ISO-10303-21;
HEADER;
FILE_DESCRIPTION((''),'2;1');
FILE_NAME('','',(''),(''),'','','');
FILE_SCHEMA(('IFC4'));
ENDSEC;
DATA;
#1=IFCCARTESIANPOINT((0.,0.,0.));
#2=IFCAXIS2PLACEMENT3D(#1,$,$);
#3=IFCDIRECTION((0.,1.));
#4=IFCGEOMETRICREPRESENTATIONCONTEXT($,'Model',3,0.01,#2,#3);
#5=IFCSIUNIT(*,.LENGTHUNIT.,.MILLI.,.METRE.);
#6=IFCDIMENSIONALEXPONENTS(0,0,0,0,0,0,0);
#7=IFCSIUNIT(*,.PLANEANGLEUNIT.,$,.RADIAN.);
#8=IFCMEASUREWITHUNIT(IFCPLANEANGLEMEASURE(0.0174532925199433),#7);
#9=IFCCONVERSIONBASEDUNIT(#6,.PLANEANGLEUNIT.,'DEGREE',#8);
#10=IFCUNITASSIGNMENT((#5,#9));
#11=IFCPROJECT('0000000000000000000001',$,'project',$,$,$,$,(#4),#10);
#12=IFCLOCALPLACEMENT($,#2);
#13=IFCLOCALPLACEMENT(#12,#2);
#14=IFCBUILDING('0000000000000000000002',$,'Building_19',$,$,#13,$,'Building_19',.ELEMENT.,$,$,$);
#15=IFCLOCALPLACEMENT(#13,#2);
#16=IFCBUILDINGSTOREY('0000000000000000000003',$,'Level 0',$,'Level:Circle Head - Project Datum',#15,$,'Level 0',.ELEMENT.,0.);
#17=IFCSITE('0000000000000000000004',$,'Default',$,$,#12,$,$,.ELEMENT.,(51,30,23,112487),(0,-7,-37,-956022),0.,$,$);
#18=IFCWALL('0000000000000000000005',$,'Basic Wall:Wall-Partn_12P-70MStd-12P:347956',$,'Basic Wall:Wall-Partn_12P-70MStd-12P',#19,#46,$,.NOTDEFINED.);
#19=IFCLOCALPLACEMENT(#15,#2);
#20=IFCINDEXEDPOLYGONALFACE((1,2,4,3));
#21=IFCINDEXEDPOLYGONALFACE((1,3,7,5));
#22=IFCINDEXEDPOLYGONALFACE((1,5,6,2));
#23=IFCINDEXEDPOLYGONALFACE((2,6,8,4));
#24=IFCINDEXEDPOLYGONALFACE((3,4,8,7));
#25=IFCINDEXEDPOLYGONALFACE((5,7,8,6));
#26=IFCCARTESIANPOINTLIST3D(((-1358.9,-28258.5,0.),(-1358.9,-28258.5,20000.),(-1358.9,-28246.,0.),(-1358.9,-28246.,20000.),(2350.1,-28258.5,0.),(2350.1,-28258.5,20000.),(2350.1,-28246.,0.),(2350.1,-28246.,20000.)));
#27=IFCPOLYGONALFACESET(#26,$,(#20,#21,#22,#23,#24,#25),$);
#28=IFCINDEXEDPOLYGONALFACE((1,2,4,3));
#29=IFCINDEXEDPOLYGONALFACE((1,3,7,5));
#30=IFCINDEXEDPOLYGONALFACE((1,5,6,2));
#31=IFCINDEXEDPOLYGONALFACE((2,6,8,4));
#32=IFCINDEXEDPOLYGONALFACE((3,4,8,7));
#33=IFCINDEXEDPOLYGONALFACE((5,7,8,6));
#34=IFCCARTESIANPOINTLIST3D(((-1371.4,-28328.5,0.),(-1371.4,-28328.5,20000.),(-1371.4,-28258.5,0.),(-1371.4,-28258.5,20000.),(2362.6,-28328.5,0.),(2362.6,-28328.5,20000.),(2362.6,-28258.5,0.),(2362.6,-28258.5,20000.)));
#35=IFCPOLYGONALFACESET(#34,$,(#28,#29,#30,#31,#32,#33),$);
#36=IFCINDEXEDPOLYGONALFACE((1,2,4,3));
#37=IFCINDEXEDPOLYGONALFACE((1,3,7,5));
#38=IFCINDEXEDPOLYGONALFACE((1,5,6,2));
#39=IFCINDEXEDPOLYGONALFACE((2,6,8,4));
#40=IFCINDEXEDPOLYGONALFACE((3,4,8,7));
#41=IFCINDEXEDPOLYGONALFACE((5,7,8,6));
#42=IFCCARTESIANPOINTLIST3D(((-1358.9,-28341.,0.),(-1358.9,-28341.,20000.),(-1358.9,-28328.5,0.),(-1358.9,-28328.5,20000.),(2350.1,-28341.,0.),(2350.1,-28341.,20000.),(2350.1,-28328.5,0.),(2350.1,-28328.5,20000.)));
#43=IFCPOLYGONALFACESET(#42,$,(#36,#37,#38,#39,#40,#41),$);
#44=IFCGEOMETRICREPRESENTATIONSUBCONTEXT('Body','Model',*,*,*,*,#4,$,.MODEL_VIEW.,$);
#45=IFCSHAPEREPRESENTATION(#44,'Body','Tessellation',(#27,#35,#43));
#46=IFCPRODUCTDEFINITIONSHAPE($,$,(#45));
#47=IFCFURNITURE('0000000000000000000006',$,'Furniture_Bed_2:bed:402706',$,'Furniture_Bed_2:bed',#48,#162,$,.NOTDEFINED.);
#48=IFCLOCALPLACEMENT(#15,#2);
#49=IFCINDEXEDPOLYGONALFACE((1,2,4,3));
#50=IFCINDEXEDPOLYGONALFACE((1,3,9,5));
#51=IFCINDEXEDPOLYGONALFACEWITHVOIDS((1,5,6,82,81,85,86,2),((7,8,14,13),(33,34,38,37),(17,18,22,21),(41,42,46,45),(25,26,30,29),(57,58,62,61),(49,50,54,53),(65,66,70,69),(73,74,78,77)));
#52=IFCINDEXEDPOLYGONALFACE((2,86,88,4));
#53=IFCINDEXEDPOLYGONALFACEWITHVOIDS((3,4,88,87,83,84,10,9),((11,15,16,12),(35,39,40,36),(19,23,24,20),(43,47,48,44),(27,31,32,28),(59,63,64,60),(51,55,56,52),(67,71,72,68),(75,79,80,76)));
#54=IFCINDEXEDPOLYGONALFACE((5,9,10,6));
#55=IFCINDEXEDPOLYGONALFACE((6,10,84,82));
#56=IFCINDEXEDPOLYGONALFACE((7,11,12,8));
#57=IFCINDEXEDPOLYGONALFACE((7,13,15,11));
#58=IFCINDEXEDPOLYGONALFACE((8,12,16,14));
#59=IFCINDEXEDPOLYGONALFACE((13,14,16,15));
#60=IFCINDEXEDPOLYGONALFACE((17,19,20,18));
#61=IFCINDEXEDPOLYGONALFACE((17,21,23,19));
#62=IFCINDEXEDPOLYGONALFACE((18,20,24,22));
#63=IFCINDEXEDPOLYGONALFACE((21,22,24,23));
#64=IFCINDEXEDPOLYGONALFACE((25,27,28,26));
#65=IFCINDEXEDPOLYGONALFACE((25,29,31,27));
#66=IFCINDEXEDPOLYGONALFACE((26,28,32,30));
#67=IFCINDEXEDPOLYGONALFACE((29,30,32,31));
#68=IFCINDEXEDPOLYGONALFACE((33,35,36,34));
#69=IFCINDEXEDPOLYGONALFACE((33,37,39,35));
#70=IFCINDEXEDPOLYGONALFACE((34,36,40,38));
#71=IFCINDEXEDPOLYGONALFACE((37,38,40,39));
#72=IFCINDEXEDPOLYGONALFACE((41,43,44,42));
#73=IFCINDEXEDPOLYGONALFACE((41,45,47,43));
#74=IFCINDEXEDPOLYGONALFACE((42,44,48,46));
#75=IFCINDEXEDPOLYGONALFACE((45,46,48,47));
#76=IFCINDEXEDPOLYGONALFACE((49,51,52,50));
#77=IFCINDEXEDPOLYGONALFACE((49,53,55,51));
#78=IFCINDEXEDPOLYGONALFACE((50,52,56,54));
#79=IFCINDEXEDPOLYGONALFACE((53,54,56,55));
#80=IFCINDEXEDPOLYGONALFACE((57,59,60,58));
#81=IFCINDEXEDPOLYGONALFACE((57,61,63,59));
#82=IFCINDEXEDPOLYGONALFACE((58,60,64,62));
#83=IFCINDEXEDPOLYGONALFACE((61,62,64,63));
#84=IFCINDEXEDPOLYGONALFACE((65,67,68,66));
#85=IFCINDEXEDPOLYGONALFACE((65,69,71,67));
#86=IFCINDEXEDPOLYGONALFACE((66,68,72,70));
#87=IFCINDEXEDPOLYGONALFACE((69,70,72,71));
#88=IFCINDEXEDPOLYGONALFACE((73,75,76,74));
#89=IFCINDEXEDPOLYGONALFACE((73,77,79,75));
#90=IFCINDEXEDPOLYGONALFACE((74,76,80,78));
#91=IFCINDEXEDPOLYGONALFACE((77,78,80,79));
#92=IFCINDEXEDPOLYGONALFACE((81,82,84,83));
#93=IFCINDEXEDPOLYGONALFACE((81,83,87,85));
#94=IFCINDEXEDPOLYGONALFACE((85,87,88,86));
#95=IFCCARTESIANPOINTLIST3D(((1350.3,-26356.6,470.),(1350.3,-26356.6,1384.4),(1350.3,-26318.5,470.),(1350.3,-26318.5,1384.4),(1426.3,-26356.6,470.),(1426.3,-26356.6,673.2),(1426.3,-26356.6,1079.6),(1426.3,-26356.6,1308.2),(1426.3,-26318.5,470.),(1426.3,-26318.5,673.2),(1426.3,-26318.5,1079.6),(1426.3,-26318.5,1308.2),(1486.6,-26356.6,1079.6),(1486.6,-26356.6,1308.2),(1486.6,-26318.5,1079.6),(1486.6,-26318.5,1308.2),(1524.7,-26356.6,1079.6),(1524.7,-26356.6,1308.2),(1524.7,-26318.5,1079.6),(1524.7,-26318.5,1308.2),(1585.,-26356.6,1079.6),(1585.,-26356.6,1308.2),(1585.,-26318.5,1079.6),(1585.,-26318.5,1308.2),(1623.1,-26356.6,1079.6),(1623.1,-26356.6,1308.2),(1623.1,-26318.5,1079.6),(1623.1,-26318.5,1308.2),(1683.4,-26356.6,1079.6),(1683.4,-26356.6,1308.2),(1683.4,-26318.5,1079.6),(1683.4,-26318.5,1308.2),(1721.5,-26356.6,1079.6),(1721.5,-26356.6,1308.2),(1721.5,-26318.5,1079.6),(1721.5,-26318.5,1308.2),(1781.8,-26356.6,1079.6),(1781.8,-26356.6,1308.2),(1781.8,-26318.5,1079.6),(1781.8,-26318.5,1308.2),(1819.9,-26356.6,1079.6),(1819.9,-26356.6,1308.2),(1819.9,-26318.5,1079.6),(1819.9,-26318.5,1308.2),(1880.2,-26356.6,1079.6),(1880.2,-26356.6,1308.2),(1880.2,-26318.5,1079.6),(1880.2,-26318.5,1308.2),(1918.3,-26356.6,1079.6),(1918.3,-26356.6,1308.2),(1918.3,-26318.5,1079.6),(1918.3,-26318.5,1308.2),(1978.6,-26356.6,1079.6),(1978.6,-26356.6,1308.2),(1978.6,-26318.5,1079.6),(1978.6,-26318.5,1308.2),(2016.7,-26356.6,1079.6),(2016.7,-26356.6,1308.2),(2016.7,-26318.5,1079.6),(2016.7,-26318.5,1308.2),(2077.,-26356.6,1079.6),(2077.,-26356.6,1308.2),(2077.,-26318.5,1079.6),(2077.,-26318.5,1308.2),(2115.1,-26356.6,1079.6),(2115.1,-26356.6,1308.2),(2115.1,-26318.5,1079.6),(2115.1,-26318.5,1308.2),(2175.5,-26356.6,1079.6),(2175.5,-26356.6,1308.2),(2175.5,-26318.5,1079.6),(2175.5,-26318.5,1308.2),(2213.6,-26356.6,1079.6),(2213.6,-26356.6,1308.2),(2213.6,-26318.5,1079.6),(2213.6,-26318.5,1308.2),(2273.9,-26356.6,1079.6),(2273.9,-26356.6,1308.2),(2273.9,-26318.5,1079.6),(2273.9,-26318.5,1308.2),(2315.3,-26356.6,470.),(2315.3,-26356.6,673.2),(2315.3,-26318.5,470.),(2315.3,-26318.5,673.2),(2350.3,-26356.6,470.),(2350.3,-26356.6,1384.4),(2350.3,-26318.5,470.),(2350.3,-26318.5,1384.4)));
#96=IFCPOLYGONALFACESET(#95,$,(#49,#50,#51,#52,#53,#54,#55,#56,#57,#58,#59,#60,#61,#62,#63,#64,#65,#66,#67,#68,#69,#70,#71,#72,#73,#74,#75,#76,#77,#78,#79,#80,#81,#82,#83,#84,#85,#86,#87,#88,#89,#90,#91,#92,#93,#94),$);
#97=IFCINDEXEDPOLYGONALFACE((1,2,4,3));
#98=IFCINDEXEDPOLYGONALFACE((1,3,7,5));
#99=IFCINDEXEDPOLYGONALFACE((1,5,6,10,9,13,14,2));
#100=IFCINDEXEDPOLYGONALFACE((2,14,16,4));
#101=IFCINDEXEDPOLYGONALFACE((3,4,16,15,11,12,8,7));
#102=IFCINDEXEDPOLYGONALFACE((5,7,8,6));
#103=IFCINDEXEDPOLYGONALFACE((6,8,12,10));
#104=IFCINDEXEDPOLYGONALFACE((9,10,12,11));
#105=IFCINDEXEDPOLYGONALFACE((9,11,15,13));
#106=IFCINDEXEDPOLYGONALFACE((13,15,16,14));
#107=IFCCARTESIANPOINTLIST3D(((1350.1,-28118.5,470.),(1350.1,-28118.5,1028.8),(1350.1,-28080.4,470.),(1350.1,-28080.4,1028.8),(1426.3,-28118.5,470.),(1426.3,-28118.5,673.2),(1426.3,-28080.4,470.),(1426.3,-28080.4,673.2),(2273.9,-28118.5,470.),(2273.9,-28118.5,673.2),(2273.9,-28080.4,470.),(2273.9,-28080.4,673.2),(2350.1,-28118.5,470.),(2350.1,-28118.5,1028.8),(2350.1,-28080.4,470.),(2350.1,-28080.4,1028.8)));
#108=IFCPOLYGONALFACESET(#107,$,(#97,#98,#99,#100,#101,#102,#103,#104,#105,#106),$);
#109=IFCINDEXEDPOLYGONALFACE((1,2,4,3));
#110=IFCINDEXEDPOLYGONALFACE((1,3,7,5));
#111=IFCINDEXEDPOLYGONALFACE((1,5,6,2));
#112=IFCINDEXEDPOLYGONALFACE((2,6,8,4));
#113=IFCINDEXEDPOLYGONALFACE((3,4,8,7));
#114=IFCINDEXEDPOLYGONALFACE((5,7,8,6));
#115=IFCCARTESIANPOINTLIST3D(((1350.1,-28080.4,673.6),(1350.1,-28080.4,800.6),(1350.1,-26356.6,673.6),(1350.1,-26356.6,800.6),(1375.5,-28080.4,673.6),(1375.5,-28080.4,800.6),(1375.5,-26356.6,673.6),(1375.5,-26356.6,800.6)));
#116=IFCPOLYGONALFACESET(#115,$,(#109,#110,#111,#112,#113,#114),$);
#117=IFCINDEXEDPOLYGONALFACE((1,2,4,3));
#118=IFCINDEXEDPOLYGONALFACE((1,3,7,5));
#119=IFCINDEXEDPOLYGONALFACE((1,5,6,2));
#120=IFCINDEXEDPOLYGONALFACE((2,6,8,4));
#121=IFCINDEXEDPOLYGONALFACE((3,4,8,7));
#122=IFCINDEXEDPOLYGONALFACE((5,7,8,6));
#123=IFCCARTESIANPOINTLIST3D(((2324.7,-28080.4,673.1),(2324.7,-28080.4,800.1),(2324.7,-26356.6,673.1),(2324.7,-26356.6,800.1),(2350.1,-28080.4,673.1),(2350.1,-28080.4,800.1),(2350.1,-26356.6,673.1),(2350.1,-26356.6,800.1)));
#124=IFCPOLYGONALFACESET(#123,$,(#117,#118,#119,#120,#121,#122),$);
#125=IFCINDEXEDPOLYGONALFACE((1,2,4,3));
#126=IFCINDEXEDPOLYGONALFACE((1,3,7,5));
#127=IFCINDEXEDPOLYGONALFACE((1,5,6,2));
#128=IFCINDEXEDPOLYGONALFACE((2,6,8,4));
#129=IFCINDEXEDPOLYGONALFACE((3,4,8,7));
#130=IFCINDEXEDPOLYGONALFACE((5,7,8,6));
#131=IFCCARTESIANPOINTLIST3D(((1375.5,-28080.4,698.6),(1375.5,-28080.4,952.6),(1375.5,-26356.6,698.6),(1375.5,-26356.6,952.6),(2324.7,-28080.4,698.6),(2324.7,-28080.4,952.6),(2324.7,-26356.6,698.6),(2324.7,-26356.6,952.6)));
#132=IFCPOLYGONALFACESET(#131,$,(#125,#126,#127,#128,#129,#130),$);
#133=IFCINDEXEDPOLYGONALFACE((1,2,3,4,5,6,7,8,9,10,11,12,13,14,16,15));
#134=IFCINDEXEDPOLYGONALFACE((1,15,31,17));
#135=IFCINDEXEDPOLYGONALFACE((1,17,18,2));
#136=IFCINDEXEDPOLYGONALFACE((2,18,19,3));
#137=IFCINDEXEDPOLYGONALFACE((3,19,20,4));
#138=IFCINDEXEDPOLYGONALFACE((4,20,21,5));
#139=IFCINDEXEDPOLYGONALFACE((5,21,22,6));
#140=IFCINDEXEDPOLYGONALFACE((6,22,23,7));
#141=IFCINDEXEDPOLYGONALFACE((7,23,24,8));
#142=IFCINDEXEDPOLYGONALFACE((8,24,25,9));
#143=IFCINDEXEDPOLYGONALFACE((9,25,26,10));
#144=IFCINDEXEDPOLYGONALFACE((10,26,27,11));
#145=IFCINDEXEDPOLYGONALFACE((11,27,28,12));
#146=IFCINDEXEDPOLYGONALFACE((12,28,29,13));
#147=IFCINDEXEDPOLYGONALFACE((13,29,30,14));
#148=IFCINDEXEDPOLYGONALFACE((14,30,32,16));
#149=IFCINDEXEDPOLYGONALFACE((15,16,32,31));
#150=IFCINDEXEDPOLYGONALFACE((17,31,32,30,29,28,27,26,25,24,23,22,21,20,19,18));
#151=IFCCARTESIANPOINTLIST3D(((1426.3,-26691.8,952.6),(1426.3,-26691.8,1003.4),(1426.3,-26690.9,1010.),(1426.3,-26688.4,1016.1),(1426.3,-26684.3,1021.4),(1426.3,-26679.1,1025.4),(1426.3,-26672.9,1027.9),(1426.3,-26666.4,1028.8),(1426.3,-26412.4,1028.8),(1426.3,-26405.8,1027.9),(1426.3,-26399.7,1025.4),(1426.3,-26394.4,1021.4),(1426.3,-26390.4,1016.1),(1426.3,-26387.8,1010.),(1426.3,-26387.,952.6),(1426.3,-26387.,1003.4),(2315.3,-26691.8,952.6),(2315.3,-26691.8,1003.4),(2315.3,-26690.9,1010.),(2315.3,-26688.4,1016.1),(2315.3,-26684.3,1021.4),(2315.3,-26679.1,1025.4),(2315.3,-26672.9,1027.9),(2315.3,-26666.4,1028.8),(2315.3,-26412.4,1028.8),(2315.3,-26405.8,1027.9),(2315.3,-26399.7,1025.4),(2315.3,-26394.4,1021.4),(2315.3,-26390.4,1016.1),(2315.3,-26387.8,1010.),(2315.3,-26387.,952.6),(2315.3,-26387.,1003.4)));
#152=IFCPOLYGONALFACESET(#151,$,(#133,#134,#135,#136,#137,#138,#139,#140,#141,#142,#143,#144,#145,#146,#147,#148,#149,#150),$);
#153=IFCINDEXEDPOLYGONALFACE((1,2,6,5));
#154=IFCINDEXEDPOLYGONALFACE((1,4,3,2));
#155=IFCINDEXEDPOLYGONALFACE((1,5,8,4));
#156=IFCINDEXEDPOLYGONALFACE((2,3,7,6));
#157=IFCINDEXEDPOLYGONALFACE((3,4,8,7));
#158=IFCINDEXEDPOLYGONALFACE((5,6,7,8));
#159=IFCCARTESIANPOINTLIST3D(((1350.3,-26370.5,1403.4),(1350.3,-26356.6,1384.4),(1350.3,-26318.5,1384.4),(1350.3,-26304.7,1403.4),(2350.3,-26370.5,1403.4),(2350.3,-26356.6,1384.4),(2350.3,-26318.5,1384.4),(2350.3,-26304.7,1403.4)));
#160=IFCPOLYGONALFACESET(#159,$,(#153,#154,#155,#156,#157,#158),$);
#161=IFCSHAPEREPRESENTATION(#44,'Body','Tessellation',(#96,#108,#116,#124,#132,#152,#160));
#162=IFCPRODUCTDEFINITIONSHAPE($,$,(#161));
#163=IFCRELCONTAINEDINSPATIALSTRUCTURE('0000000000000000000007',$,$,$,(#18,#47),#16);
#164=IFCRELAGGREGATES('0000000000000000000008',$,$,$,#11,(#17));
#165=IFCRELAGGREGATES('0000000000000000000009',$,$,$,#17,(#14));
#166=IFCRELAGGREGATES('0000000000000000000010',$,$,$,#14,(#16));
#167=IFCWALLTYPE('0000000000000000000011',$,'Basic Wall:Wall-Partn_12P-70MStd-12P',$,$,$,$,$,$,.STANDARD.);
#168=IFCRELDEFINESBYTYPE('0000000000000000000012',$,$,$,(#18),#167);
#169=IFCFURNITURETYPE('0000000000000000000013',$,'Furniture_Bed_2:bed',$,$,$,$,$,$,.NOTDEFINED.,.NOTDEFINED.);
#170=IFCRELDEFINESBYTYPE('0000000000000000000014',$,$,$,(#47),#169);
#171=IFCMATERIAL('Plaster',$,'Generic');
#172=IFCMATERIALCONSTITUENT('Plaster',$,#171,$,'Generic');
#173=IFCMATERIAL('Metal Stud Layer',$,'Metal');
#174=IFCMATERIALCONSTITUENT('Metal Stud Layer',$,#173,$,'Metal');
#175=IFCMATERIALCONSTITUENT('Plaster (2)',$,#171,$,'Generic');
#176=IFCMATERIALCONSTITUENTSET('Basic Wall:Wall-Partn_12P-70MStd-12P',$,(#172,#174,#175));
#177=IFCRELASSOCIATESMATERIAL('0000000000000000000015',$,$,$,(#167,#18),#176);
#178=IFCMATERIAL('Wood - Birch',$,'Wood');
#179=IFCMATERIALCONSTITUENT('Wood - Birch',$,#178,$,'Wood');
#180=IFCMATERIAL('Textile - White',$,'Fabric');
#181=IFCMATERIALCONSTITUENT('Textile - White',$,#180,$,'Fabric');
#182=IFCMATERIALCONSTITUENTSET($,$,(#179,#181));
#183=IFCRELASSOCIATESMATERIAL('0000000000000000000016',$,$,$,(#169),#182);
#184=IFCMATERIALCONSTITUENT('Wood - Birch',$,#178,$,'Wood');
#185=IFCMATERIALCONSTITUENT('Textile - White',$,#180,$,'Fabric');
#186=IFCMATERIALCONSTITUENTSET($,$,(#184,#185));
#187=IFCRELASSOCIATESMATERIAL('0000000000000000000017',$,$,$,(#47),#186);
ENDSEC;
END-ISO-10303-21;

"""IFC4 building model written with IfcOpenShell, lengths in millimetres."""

from ifc_helpers import new_model, entity, si_unit, converted_unit, direction, frame, origin, place, context, subcontext, project, spatial, line, arc, indexed_curve, outline, extrude, source, transform, mapped, material, constituent, constituent_set, type_object, type_shapes, element, save


model = new_model("IFC4")

# Units and contexts
model_context = context("Model", 3, precision=0.01, world=origin(), true_north=direction((0.0, 1.0)))
body_context = subcontext(model_context, "Body", "Model", "MODEL_VIEW")
ifc_project = project(units=[si_unit("LENGTHUNIT", "METRE", prefix="MILLI"), converted_unit("PLANEANGLEUNIT", "DEGREE", entity("IfcPlaneAngleMeasure", 0.0174532925199433), si_unit("PLANEANGLEUNIT", "RADIAN"), dimensions=[0, 0, 0, 0, 0, 0, 0])], contexts=[model_context])

# Site, building, storey
site_placement = place(None, origin())
site = spatial("IfcSite", under=ifc_project, at=site_placement, Name="Default", CompositionType="ELEMENT", RefLatitude=(51, 30, 23, 112487), RefLongitude=(0, -7, -37, -956022), RefElevation=0.0)
building_placement = place(site_placement, origin())
building = spatial("IfcBuilding", under=site, at=building_placement, Name="Building_19", LongName="Building_19", CompositionType="ELEMENT")
storey_placement = place(building_placement, origin())
storey = spatial("IfcBuildingStorey", under=building, at=storey_placement, Name="Level 0", ObjectType="Level:Circle Head - Project Datum", LongName="Level 0", CompositionType="ELEMENT", Elevation=0.0)

# Shared definitions
ifc_material_1 = material(Name="Plaster", Category="Generic")

# Shared definitions
ifc_constituent_1 = constituent(ifc_material_1, Name="Plaster", Category="Generic")
ifc_material_2 = material(Name="Metal Stud Layer", Category="Metal")
ifc_constituent_2 = constituent(ifc_material_2, Name="Metal Stud Layer", Category="Metal")
ifc_constituent_3 = constituent(ifc_material_1, Name="Plaster (2)", Category="Generic")
ifc_constituent_set_1 = constituent_set(constituents=[ifc_constituent_1, ifc_constituent_2, ifc_constituent_3], Name="Basic Wall:Wall-Partn_12P-70MStd-12P")
wall_type_1 = type_object("IfcWallType", Name="Basic Wall:Wall-Partn_12P-70MStd-12P", PredefinedType="STANDARD", material=ifc_constituent_set_1)

# Wall
wall_1_placement = place(storey_placement, frame((-1358.9, -28293.5, 0.0)))
element("IfcWall", 1, at=wall_1_placement, inside=storey, type_object=wall_type_1, material=ifc_constituent_set_1, Name="Basic Wall:Wall-Partn_12P-70MStd-12P:347956", ObjectType="Basic Wall:Wall-Partn_12P-70MStd-12P", PredefinedType="NOTDEFINED", context=body_context, shape_type="SweptSolid", body=[
    extrude(outline(indexed_curve([(-6.3, -1854.5), (6.2, -1854.5), (6.3, 1854.5), (-6.2, 1854.5), (-6.3, -1854.5)], self_intersect=False)), frame((1854.5, 41.2, 0.0), z_axis=(0.0, 0.0, 1.0), x_axis=(0.0, -1.0, 0.0)), (0.0, 0.0, 1.0), 20000.0),
    extrude(outline(indexed_curve([(-1867.0, -35.0), (1867.0, -35.0), (1867.0, 35.0), (-1867.0, 35.0), (-1867.0, -35.0)], self_intersect=False)), frame((1854.5, 0.0, 0.0)), (0.0, 0.0, 1.0), 20000.0),
    extrude(outline(indexed_curve([(-6.3, -1854.5), (6.2, -1854.5), (6.3, 1854.5), (-6.2, 1854.5), (-6.3, -1854.5)], self_intersect=False)), frame((1854.5, -41.3, 0.0), z_axis=(0.0, 0.0, 1.0), x_axis=(0.0, 1.0, 0.0)), (0.0, 0.0, 1.0), 20000.0),
])

# Furniture
ifc_material_3 = material(Name="Wood - Birch", Category="Wood")
ifc_constituent_4 = constituent(ifc_material_3, Name="Wood - Birch", Category="Wood")
ifc_material_4 = material(Name="Textile - White", Category="Fabric")
ifc_constituent_5 = constituent(ifc_material_4, Name="Textile - White", Category="Fabric")
ifc_constituent_set_2 = constituent_set(constituents=[ifc_constituent_4, ifc_constituent_5])
ifc_constituent_6 = constituent(ifc_material_3, Name="Wood - Birch", Category="Wood")
ifc_constituent_7 = constituent(ifc_material_4, Name="Textile - White", Category="Fabric")
ifc_constituent_set_3 = constituent_set(constituents=[ifc_constituent_6, ifc_constituent_7])
furniture_type_1 = type_object("IfcFurnitureType", Name="Furniture_Bed_2:bed", AssemblyPlace="NOTDEFINED", PredefinedType="NOTDEFINED", material=ifc_constituent_set_3)
shared_shape_1 = source(origin(), body_context, "Body", "SweptSolid", [
    extrude(outline(indexed_curve([(-635.0, -489.8), (279.4, -489.8), (279.4, -454.7), (76.2, -454.7), (76.2, 434.3), (279.4, 434.3), (279.4, 510.3), (-635.0, 510.3), (-635.0, -489.8)], self_intersect=False), holes=[indexed_curve([(-558.8, 374.0), (-558.8, 434.3), (-330.2, 434.3), (-330.2, 374.0), (-558.8, 374.0)], self_intersect=False), indexed_curve([(-558.8, 275.5), (-558.8, 335.9), (-330.2, 335.9), (-330.2, 275.5), (-558.8, 275.5)], self_intersect=False), indexed_curve([(-558.8, 177.1), (-558.8, 237.4), (-330.2, 237.4), (-330.2, 177.1), (-558.8, 177.1)], self_intersect=False), indexed_curve([(-558.8, 78.7), (-558.8, 139.0), (-330.2, 139.0), (-330.2, 78.7), (-558.8, 78.7)], self_intersect=False), indexed_curve([(-558.8, -118.1), (-558.8, -57.8), (-330.2, -57.8), (-330.2, -118.1), (-558.8, -118.1)], self_intersect=False), indexed_curve([(-558.8, -216.5), (-558.8, -156.2), (-330.2, -156.2), (-330.2, -216.5), (-558.8, -216.5)], self_intersect=False), indexed_curve([(-558.8, -314.9), (-558.8, -254.6), (-330.2, -254.6), (-330.2, -314.9), (-558.8, -314.9)], self_intersect=False), indexed_curve([(-558.8, -413.3), (-558.8, -353.0), (-330.2, -353.0), (-330.2, -413.3), (-558.8, -413.3)], self_intersect=False), indexed_curve([(-558.8, -19.7), (-558.8, 40.6), (-330.2, 40.6), (-330.2, -19.7), (-558.8, -19.7)], self_intersect=False)]), frame((-8.6, -38.1, 279.4), z_axis=(0.0, 1.0, 0.0), x_axis=(0.0, 0.0, -1.0)), (0.0, 0.0, 1.0), 38.1),
    extrude(outline(indexed_curve([(423.8, -190.5), (500.0, -190.5), (500.0, 368.3), (-500.0, 368.3), (-500.0, -190.5), (-423.8, -190.5), (-423.8, 12.7), (423.8, 12.7), (423.8, -190.5)], self_intersect=False)), frame((-19.1, -1800.0, 190.5), z_axis=(0.0, 1.0, 0.0), x_axis=(-1.0, 0.0, 0.0)), (0.0, 0.0, 1.0), 38.1),
    extrude(outline(indexed_curve([(-12.7, -861.9), (12.7, -861.9), (12.7, 861.9), (-12.7, 861.9), (-12.7, -861.9)], self_intersect=False)), frame((-506.4, -900.0, 203.6)), (0.0, 0.0, 1.0), 127.0),
    extrude(outline(indexed_curve([(-12.7, -861.9), (12.7, -861.9), (12.7, 861.9), (-12.7, 861.9), (-12.7, -861.9)], self_intersect=False)), frame((468.2, -900.0, 203.1)), (0.0, 0.0, 1.0), 127.0),
    extrude(outline(indexed_curve([(-474.6, -861.9), (474.6, -861.9), (474.6, 861.9), (-474.6, 861.9), (-474.6, -861.9)], self_intersect=False)), frame((-19.0, -900.0, 228.6), z_axis=(0.0, 0.0, 1.0), x_axis=(-1.0, 0.0, 0.0)), (0.0, 0.0, 1.0), 254.0),
    extrude(outline(indexed_curve([(-152.4, -42.3), (152.4, -42.3), (152.4, 8.5), (145.0, 26.4), (127.0, 33.9), (-127.0, 33.9), (-145.0, 26.4), (-152.4, 8.5)], segments=[line(1, 2, 3), arc(3, 4, 5), line(5, 6), arc(6, 7, 8), line(8, 1)], self_intersect=False)), frame((-442.9, -220.8, 524.9), z_axis=(1.0, 0.0, 0.0), x_axis=(0.0, 1.0, 0.0)), (0.0, 0.0, 1.0), 889.0),
    extrude(outline(indexed_curve([(-19.1, -9.5), (19.0, -9.5), (32.9, 9.5), (-32.9, 9.5), (-19.1, -9.5)], self_intersect=False)), frame((-518.8, -19.0, 923.9), z_axis=(1.0, 0.0, 0.0), x_axis=(0.0, 1.0, 0.0)), (0.0, 0.0, 1.0), 1000.1),
])
type_shapes(furniture_type_1, [shared_shape_1])
furniture_1_placement = place(storey_placement, frame((1869.1, -26318.5, 470.0)))
element("IfcFurniture", 2, at=furniture_1_placement, inside=storey, type_object=furniture_type_1, material=ifc_constituent_set_2, Name="Furniture_Bed_2:bed:402706", ObjectType="Furniture_Bed_2:bed", PredefinedType="NOTDEFINED", context=body_context, shape_type="MappedRepresentation", body=[
    mapped(shared_shape_1, transform((0.0, 0.0, 0.0), scale=1.0)),
])

save(model, "model.ifc")
